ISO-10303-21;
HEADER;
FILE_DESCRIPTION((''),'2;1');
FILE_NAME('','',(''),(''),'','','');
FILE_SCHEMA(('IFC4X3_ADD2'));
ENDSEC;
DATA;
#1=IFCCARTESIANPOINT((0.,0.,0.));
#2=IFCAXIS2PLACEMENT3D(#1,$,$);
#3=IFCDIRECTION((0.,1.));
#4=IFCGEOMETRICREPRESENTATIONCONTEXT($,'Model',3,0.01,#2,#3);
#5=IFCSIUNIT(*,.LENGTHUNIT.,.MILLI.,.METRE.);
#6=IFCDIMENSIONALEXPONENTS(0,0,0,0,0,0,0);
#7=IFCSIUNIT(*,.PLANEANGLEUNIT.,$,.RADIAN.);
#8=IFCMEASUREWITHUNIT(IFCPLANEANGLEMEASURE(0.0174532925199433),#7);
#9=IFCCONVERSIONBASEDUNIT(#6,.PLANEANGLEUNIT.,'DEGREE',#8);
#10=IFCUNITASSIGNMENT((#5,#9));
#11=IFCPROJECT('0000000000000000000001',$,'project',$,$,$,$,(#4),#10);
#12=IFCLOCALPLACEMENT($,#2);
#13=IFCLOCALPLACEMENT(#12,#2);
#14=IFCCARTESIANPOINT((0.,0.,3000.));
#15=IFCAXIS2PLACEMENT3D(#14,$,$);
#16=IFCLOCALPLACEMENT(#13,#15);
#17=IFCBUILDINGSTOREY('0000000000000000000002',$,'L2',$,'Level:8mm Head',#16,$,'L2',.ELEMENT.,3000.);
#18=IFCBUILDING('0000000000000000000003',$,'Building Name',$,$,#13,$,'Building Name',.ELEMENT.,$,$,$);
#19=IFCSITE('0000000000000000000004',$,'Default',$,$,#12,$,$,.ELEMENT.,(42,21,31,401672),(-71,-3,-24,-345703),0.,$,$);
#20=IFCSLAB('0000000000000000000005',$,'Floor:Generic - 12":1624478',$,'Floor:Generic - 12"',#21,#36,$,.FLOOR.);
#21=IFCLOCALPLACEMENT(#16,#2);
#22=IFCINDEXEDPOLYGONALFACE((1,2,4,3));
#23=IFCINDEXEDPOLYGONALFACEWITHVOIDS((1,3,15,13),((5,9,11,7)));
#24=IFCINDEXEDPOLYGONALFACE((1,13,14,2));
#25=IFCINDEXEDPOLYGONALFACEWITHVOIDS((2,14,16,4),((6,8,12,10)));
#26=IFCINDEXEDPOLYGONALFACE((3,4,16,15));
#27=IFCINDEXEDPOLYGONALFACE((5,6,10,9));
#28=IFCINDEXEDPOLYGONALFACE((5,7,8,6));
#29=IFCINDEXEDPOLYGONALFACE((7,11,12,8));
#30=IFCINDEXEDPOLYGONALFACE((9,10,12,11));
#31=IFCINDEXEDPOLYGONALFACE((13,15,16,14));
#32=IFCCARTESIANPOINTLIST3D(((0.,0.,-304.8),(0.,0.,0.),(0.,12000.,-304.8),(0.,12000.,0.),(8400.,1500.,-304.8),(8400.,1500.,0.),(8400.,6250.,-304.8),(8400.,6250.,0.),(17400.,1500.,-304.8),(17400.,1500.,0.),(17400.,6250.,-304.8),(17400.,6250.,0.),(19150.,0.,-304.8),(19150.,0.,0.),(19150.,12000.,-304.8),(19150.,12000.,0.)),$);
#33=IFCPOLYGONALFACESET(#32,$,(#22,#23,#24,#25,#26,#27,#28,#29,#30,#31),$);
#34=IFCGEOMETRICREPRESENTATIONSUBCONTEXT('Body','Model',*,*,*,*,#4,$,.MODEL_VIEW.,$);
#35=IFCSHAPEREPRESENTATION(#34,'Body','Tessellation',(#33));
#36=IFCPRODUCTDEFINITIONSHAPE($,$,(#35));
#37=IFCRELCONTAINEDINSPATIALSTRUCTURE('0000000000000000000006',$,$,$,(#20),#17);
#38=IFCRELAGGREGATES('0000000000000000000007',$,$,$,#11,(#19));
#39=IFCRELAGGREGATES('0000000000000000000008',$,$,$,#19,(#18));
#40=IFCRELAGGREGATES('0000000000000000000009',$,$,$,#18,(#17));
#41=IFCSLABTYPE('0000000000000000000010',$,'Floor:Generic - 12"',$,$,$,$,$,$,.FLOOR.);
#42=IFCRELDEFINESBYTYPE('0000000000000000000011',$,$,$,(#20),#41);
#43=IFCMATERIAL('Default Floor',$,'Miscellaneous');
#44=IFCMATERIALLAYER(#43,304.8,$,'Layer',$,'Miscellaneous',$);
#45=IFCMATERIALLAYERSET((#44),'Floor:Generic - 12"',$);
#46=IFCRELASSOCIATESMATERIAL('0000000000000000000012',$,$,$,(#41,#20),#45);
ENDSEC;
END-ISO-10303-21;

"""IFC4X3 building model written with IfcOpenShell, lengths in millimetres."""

from ifc_helpers import new_model, entity, si_unit, converted_unit, direction, frame, frame_2d, origin, place, context, subcontext, project, spatial, rectangle, extrude, boolean, material, layer, layer_set, layer_usage, type_object, element, save


model = new_model("IFC4X3")

# Units and contexts
model_context = context("Model", 3, precision=0.01, world=origin(), true_north=direction((0.0, 1.0)))
body_context = subcontext(model_context, "Body", "Model", "MODEL_VIEW")
ifc_project = project(units=[si_unit("LENGTHUNIT", "METRE", prefix="MILLI"), converted_unit("PLANEANGLEUNIT", "DEGREE", entity("IfcPlaneAngleMeasure", 0.0174532925199433), si_unit("PLANEANGLEUNIT", "RADIAN"), dimensions=[0, 0, 0, 0, 0, 0, 0])], contexts=[model_context])

# Site, building, storey
site_placement = place(None, origin())
site = spatial("IfcSite", under=ifc_project, at=site_placement, Name="Default", CompositionType="ELEMENT", RefLatitude=(42, 21, 31, 401672), RefLongitude=(-71, -3, -24, -345703), RefElevation=0.0)
building_placement = place(site_placement, origin())
building = spatial("IfcBuilding", under=site, at=building_placement, Name="Building Name", LongName="Building Name", CompositionType="ELEMENT")
storey_placement = place(building_placement, frame((0.0, 0.0, 3000.0)))
storey = spatial("IfcBuildingStorey", under=building, at=storey_placement, Name="L2", ObjectType="Level:8mm Head", LongName="L2", CompositionType="ELEMENT", Elevation=3000.0)

# Slab, opening
ifc_material = material(Name="Default Floor", Category="Miscellaneous")
ifc_layer = layer(ifc_material, 304.8, Name="Layer", Category="Miscellaneous")
ifc_layer_set = layer_set([ifc_layer], Name="Floor:Generic - 12\"")
ifc_layer_usage = layer_usage(ifc_layer_set, "AXIS3", "POSITIVE", 0.0)
slab_type = type_object("IfcSlabType", Name="Floor:Generic - 12\"", PredefinedType="FLOOR", material=ifc_layer_set)
slab_placement = place(storey_placement, origin())
slab = element("IfcSlab", 1, at=slab_placement, inside=storey, type_object=slab_type, material=ifc_layer_usage, Name="Floor:Generic - 12\":1624478", ObjectType="Floor:Generic - 12\"", PredefinedType="FLOOR", context=body_context, shape_type="SweptSolid", body=[
    boolean("DIFFERENCE", extrude(rectangle(XDim=12000.0, YDim=19150.0, at=frame_2d((0.0, 0.0), x_axis=(1.0, 0.0))), frame((9575.0, 6000.0, 0.0), z_axis=(0.0, 0.0, -1.0), x_axis=(0.0, 1.0, 0.0)), (0.0, 0.0, 1.0), 304.8), extrude(rectangle(XDim=4750.0, YDim=9000.0, at=frame_2d((0.0, 0.0), x_axis=(1.0, 0.0))), frame((12900.0, 3875.0, 0.0), z_axis=(0.0, 0.0, -1.0), x_axis=(0.0, -1.0, 0.0)), (0.0, 0.0, 1.0), 304.8)),
])
opening_placement = place(slab_placement, origin())
element("IfcOpeningElement", 2, at=opening_placement, cuts=slab, PredefinedType="OPENING", context=body_context, shape_type="SweptSolid", body=[
    extrude(rectangle(XDim=4750.0, YDim=9000.0, at=frame_2d((0.0, 0.0), x_axis=(1.0, 0.0))), frame((12900.0, 3875.0, -304.8), z_axis=(0.0, 0.0, 1.0), x_axis=(0.0, -1.0, 0.0)), (0.0, 0.0, 1.0), 304.8),
])

save(model, "model.ifc")
